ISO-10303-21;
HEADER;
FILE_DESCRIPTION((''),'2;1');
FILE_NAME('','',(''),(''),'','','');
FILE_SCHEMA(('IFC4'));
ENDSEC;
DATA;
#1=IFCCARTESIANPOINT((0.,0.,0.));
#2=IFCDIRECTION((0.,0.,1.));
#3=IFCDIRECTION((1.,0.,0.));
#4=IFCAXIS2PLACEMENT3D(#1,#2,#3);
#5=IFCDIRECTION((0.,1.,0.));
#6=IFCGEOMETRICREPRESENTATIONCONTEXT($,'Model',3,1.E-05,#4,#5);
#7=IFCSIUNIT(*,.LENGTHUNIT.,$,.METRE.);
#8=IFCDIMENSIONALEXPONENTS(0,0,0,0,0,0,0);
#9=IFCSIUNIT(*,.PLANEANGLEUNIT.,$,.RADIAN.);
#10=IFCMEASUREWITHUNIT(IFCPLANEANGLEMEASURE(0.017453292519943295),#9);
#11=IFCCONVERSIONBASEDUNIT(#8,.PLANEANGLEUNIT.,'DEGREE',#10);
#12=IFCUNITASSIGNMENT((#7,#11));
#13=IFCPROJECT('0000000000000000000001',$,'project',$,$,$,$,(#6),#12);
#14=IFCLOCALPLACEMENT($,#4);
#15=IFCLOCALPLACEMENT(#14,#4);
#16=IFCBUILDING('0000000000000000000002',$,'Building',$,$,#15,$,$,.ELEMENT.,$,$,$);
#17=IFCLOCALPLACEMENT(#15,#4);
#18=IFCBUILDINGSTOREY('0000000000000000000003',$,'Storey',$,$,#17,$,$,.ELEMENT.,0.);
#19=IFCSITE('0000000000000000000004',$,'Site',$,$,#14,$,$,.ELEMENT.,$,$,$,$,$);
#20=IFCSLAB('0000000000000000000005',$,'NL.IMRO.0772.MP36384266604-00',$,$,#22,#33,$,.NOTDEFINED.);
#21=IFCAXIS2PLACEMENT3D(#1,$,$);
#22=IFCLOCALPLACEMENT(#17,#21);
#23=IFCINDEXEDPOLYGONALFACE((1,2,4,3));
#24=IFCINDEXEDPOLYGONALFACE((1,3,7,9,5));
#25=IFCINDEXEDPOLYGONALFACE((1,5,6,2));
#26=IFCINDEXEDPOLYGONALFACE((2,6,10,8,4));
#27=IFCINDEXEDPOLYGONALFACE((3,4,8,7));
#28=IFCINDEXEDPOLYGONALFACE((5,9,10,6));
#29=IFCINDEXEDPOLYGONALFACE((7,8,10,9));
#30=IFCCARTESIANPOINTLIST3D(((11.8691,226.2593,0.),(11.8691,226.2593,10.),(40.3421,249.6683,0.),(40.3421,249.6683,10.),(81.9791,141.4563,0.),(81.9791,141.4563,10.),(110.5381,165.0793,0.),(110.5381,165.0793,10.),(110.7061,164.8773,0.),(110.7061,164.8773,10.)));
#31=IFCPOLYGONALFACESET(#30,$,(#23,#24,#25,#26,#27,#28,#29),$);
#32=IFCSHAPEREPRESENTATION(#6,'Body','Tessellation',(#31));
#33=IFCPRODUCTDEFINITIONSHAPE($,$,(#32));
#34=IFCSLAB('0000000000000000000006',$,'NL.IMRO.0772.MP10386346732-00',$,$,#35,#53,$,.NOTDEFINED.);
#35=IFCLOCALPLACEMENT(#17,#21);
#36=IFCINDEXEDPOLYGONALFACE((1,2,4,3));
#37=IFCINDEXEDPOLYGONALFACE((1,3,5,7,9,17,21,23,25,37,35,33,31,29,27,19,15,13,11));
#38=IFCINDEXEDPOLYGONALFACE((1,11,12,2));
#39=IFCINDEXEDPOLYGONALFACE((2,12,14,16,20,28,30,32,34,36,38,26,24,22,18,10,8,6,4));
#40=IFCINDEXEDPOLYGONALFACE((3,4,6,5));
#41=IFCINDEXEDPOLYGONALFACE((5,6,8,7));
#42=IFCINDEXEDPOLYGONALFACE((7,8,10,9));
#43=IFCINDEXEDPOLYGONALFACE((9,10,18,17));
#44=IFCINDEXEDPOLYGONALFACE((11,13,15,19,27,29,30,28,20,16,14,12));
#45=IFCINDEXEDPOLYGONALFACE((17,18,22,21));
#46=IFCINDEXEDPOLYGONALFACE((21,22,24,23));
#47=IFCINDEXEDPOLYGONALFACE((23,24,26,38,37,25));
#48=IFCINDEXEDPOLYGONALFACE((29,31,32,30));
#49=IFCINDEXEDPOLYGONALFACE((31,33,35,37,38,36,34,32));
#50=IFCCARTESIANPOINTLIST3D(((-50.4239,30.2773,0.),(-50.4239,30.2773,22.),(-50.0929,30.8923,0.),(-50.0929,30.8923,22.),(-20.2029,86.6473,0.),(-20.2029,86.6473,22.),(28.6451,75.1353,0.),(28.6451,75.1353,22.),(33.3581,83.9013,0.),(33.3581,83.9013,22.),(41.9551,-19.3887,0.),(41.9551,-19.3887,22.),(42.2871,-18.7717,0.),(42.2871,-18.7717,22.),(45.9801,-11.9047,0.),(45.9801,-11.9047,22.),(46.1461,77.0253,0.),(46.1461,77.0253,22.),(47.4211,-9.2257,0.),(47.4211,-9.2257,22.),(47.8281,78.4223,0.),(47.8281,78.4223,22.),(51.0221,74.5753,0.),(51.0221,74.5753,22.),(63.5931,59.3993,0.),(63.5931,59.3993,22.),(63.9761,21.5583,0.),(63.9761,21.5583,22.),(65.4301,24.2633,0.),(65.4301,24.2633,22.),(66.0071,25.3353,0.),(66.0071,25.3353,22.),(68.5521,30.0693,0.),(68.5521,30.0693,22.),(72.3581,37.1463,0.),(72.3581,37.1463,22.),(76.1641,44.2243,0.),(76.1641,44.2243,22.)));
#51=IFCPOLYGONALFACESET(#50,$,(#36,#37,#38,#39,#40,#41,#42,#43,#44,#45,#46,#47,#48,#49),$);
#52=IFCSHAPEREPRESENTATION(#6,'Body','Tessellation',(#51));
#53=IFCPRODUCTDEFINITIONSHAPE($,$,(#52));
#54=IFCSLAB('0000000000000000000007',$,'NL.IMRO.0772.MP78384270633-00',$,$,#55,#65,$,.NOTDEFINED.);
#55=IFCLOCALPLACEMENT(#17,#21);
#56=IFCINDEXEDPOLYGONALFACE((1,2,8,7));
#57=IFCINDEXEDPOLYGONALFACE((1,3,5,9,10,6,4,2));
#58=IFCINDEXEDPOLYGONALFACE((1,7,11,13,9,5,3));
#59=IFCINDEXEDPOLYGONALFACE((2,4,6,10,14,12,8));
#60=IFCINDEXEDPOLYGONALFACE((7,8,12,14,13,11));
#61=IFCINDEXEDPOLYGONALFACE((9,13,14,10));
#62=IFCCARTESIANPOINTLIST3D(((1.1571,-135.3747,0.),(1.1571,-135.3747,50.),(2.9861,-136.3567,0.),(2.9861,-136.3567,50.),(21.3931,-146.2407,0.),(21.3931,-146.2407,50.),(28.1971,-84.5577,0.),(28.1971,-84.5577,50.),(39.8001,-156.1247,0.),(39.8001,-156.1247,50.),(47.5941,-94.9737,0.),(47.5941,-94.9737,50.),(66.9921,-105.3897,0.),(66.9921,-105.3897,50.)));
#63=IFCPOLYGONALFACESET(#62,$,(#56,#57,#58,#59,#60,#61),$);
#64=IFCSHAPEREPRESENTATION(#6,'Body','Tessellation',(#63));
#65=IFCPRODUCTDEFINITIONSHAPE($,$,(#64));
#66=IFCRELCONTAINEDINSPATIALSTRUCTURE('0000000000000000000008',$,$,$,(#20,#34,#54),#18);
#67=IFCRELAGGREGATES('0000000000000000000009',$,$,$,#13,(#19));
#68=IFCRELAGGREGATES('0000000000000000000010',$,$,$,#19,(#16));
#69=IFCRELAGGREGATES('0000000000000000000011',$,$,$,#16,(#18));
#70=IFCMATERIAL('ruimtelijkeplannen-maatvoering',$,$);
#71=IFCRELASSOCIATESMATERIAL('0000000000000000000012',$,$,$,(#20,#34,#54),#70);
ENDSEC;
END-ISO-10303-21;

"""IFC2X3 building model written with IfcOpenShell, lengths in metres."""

from ifc_helpers import new_model, entity, si_unit, converted_unit, direction, origin_with_axes, place, context, project, spatial, polyline, outline, extrude, material, element, save


model = new_model("IFC2X3")

# Units and contexts
model_context = context("Model", 3, precision=1e-05, world=origin_with_axes(), true_north=direction((0.0, 1.0, 0.0)))
ifc_project = project(units=[si_unit("LENGTHUNIT", "METRE"), converted_unit("PLANEANGLEUNIT", "DEGREE", entity("IfcPlaneAngleMeasure", 0.017453292519943295), si_unit("PLANEANGLEUNIT", "RADIAN"), dimensions=[0, 0, 0, 0, 0, 0, 0])], contexts=[model_context])

# Site, building, storey
site_placement = place(None, origin_with_axes())
site = spatial("IfcSite", under=ifc_project, at=site_placement, Name="Site", CompositionType="ELEMENT")
building_placement = place(site_placement, origin_with_axes())
building = spatial("IfcBuilding", under=site, at=building_placement, Name="Building", CompositionType="ELEMENT")
storey_placement = place(building_placement, origin_with_axes())
storey = spatial("IfcBuildingStorey", under=building, at=storey_placement, Name="Storey", CompositionType="ELEMENT", Elevation=0.0)

# Slabs
ifc_material = material(Name="ruimtelijkeplannen-maatvoering")
slab_1_placement = place(storey_placement, origin_with_axes())
element("IfcSlab", 1, at=slab_1_placement, inside=storey, material=ifc_material, Name="NL.IMRO.0772.MP36384266604-00", PredefinedType="NOTDEFINED", context=model_context, shape_type="SweptSolid", body=[
    extrude(outline(polyline([(110.7061, 164.8773), (81.9791, 141.4563), (11.8691, 226.2593), (40.3421, 249.6683), (110.5381, 165.0793), (110.7061, 164.8773)])), origin_with_axes(), (0.0, 0.0, 1.0), 10.0),
])
slab_2_placement = place(storey_placement, origin_with_axes())
element("IfcSlab", 2, at=slab_2_placement, inside=storey, material=ifc_material, Name="NL.IMRO.0772.MP10386346732-00", PredefinedType="NOTDEFINED", context=model_context, shape_type="SweptSolid", body=[
    extrude(outline(polyline([(66.0071, 25.3353), (65.4301, 24.2633), (63.9761, 21.5583), (47.4211, -9.2257), (45.9801, -11.9047), (42.2871, -18.7717), (41.9551, -19.3887), (-50.4239, 30.2773), (-50.0929, 30.8923), (-20.2029, 86.6473), (28.6451, 75.1353), (33.3581, 83.9013), (46.1461, 77.0253), (47.8281, 78.4223), (51.0221, 74.5753), (63.5931, 59.3993), (76.1641, 44.2243), (72.3581, 37.1463), (68.5521, 30.0693), (66.0071, 25.3353)])), origin_with_axes(), (0.0, 0.0, 1.0), 22.0),
])
slab_3_placement = place(storey_placement, origin_with_axes())
element("IfcSlab", 3, at=slab_3_placement, inside=storey, material=ifc_material, Name="NL.IMRO.0772.MP78384270633-00", PredefinedType="NOTDEFINED", context=model_context, shape_type="SweptSolid", body=[
    extrude(outline(polyline([(47.5941, -94.9737), (66.9921, -105.3897), (39.8001, -156.1247), (21.3931, -146.2407), (2.9861, -136.3567), (1.1571, -135.3747), (28.1971, -84.5577), (47.5941, -94.9737)])), origin_with_axes(), (0.0, 0.0, 1.0), 50.0),
])

save(model, "model.ifc")
